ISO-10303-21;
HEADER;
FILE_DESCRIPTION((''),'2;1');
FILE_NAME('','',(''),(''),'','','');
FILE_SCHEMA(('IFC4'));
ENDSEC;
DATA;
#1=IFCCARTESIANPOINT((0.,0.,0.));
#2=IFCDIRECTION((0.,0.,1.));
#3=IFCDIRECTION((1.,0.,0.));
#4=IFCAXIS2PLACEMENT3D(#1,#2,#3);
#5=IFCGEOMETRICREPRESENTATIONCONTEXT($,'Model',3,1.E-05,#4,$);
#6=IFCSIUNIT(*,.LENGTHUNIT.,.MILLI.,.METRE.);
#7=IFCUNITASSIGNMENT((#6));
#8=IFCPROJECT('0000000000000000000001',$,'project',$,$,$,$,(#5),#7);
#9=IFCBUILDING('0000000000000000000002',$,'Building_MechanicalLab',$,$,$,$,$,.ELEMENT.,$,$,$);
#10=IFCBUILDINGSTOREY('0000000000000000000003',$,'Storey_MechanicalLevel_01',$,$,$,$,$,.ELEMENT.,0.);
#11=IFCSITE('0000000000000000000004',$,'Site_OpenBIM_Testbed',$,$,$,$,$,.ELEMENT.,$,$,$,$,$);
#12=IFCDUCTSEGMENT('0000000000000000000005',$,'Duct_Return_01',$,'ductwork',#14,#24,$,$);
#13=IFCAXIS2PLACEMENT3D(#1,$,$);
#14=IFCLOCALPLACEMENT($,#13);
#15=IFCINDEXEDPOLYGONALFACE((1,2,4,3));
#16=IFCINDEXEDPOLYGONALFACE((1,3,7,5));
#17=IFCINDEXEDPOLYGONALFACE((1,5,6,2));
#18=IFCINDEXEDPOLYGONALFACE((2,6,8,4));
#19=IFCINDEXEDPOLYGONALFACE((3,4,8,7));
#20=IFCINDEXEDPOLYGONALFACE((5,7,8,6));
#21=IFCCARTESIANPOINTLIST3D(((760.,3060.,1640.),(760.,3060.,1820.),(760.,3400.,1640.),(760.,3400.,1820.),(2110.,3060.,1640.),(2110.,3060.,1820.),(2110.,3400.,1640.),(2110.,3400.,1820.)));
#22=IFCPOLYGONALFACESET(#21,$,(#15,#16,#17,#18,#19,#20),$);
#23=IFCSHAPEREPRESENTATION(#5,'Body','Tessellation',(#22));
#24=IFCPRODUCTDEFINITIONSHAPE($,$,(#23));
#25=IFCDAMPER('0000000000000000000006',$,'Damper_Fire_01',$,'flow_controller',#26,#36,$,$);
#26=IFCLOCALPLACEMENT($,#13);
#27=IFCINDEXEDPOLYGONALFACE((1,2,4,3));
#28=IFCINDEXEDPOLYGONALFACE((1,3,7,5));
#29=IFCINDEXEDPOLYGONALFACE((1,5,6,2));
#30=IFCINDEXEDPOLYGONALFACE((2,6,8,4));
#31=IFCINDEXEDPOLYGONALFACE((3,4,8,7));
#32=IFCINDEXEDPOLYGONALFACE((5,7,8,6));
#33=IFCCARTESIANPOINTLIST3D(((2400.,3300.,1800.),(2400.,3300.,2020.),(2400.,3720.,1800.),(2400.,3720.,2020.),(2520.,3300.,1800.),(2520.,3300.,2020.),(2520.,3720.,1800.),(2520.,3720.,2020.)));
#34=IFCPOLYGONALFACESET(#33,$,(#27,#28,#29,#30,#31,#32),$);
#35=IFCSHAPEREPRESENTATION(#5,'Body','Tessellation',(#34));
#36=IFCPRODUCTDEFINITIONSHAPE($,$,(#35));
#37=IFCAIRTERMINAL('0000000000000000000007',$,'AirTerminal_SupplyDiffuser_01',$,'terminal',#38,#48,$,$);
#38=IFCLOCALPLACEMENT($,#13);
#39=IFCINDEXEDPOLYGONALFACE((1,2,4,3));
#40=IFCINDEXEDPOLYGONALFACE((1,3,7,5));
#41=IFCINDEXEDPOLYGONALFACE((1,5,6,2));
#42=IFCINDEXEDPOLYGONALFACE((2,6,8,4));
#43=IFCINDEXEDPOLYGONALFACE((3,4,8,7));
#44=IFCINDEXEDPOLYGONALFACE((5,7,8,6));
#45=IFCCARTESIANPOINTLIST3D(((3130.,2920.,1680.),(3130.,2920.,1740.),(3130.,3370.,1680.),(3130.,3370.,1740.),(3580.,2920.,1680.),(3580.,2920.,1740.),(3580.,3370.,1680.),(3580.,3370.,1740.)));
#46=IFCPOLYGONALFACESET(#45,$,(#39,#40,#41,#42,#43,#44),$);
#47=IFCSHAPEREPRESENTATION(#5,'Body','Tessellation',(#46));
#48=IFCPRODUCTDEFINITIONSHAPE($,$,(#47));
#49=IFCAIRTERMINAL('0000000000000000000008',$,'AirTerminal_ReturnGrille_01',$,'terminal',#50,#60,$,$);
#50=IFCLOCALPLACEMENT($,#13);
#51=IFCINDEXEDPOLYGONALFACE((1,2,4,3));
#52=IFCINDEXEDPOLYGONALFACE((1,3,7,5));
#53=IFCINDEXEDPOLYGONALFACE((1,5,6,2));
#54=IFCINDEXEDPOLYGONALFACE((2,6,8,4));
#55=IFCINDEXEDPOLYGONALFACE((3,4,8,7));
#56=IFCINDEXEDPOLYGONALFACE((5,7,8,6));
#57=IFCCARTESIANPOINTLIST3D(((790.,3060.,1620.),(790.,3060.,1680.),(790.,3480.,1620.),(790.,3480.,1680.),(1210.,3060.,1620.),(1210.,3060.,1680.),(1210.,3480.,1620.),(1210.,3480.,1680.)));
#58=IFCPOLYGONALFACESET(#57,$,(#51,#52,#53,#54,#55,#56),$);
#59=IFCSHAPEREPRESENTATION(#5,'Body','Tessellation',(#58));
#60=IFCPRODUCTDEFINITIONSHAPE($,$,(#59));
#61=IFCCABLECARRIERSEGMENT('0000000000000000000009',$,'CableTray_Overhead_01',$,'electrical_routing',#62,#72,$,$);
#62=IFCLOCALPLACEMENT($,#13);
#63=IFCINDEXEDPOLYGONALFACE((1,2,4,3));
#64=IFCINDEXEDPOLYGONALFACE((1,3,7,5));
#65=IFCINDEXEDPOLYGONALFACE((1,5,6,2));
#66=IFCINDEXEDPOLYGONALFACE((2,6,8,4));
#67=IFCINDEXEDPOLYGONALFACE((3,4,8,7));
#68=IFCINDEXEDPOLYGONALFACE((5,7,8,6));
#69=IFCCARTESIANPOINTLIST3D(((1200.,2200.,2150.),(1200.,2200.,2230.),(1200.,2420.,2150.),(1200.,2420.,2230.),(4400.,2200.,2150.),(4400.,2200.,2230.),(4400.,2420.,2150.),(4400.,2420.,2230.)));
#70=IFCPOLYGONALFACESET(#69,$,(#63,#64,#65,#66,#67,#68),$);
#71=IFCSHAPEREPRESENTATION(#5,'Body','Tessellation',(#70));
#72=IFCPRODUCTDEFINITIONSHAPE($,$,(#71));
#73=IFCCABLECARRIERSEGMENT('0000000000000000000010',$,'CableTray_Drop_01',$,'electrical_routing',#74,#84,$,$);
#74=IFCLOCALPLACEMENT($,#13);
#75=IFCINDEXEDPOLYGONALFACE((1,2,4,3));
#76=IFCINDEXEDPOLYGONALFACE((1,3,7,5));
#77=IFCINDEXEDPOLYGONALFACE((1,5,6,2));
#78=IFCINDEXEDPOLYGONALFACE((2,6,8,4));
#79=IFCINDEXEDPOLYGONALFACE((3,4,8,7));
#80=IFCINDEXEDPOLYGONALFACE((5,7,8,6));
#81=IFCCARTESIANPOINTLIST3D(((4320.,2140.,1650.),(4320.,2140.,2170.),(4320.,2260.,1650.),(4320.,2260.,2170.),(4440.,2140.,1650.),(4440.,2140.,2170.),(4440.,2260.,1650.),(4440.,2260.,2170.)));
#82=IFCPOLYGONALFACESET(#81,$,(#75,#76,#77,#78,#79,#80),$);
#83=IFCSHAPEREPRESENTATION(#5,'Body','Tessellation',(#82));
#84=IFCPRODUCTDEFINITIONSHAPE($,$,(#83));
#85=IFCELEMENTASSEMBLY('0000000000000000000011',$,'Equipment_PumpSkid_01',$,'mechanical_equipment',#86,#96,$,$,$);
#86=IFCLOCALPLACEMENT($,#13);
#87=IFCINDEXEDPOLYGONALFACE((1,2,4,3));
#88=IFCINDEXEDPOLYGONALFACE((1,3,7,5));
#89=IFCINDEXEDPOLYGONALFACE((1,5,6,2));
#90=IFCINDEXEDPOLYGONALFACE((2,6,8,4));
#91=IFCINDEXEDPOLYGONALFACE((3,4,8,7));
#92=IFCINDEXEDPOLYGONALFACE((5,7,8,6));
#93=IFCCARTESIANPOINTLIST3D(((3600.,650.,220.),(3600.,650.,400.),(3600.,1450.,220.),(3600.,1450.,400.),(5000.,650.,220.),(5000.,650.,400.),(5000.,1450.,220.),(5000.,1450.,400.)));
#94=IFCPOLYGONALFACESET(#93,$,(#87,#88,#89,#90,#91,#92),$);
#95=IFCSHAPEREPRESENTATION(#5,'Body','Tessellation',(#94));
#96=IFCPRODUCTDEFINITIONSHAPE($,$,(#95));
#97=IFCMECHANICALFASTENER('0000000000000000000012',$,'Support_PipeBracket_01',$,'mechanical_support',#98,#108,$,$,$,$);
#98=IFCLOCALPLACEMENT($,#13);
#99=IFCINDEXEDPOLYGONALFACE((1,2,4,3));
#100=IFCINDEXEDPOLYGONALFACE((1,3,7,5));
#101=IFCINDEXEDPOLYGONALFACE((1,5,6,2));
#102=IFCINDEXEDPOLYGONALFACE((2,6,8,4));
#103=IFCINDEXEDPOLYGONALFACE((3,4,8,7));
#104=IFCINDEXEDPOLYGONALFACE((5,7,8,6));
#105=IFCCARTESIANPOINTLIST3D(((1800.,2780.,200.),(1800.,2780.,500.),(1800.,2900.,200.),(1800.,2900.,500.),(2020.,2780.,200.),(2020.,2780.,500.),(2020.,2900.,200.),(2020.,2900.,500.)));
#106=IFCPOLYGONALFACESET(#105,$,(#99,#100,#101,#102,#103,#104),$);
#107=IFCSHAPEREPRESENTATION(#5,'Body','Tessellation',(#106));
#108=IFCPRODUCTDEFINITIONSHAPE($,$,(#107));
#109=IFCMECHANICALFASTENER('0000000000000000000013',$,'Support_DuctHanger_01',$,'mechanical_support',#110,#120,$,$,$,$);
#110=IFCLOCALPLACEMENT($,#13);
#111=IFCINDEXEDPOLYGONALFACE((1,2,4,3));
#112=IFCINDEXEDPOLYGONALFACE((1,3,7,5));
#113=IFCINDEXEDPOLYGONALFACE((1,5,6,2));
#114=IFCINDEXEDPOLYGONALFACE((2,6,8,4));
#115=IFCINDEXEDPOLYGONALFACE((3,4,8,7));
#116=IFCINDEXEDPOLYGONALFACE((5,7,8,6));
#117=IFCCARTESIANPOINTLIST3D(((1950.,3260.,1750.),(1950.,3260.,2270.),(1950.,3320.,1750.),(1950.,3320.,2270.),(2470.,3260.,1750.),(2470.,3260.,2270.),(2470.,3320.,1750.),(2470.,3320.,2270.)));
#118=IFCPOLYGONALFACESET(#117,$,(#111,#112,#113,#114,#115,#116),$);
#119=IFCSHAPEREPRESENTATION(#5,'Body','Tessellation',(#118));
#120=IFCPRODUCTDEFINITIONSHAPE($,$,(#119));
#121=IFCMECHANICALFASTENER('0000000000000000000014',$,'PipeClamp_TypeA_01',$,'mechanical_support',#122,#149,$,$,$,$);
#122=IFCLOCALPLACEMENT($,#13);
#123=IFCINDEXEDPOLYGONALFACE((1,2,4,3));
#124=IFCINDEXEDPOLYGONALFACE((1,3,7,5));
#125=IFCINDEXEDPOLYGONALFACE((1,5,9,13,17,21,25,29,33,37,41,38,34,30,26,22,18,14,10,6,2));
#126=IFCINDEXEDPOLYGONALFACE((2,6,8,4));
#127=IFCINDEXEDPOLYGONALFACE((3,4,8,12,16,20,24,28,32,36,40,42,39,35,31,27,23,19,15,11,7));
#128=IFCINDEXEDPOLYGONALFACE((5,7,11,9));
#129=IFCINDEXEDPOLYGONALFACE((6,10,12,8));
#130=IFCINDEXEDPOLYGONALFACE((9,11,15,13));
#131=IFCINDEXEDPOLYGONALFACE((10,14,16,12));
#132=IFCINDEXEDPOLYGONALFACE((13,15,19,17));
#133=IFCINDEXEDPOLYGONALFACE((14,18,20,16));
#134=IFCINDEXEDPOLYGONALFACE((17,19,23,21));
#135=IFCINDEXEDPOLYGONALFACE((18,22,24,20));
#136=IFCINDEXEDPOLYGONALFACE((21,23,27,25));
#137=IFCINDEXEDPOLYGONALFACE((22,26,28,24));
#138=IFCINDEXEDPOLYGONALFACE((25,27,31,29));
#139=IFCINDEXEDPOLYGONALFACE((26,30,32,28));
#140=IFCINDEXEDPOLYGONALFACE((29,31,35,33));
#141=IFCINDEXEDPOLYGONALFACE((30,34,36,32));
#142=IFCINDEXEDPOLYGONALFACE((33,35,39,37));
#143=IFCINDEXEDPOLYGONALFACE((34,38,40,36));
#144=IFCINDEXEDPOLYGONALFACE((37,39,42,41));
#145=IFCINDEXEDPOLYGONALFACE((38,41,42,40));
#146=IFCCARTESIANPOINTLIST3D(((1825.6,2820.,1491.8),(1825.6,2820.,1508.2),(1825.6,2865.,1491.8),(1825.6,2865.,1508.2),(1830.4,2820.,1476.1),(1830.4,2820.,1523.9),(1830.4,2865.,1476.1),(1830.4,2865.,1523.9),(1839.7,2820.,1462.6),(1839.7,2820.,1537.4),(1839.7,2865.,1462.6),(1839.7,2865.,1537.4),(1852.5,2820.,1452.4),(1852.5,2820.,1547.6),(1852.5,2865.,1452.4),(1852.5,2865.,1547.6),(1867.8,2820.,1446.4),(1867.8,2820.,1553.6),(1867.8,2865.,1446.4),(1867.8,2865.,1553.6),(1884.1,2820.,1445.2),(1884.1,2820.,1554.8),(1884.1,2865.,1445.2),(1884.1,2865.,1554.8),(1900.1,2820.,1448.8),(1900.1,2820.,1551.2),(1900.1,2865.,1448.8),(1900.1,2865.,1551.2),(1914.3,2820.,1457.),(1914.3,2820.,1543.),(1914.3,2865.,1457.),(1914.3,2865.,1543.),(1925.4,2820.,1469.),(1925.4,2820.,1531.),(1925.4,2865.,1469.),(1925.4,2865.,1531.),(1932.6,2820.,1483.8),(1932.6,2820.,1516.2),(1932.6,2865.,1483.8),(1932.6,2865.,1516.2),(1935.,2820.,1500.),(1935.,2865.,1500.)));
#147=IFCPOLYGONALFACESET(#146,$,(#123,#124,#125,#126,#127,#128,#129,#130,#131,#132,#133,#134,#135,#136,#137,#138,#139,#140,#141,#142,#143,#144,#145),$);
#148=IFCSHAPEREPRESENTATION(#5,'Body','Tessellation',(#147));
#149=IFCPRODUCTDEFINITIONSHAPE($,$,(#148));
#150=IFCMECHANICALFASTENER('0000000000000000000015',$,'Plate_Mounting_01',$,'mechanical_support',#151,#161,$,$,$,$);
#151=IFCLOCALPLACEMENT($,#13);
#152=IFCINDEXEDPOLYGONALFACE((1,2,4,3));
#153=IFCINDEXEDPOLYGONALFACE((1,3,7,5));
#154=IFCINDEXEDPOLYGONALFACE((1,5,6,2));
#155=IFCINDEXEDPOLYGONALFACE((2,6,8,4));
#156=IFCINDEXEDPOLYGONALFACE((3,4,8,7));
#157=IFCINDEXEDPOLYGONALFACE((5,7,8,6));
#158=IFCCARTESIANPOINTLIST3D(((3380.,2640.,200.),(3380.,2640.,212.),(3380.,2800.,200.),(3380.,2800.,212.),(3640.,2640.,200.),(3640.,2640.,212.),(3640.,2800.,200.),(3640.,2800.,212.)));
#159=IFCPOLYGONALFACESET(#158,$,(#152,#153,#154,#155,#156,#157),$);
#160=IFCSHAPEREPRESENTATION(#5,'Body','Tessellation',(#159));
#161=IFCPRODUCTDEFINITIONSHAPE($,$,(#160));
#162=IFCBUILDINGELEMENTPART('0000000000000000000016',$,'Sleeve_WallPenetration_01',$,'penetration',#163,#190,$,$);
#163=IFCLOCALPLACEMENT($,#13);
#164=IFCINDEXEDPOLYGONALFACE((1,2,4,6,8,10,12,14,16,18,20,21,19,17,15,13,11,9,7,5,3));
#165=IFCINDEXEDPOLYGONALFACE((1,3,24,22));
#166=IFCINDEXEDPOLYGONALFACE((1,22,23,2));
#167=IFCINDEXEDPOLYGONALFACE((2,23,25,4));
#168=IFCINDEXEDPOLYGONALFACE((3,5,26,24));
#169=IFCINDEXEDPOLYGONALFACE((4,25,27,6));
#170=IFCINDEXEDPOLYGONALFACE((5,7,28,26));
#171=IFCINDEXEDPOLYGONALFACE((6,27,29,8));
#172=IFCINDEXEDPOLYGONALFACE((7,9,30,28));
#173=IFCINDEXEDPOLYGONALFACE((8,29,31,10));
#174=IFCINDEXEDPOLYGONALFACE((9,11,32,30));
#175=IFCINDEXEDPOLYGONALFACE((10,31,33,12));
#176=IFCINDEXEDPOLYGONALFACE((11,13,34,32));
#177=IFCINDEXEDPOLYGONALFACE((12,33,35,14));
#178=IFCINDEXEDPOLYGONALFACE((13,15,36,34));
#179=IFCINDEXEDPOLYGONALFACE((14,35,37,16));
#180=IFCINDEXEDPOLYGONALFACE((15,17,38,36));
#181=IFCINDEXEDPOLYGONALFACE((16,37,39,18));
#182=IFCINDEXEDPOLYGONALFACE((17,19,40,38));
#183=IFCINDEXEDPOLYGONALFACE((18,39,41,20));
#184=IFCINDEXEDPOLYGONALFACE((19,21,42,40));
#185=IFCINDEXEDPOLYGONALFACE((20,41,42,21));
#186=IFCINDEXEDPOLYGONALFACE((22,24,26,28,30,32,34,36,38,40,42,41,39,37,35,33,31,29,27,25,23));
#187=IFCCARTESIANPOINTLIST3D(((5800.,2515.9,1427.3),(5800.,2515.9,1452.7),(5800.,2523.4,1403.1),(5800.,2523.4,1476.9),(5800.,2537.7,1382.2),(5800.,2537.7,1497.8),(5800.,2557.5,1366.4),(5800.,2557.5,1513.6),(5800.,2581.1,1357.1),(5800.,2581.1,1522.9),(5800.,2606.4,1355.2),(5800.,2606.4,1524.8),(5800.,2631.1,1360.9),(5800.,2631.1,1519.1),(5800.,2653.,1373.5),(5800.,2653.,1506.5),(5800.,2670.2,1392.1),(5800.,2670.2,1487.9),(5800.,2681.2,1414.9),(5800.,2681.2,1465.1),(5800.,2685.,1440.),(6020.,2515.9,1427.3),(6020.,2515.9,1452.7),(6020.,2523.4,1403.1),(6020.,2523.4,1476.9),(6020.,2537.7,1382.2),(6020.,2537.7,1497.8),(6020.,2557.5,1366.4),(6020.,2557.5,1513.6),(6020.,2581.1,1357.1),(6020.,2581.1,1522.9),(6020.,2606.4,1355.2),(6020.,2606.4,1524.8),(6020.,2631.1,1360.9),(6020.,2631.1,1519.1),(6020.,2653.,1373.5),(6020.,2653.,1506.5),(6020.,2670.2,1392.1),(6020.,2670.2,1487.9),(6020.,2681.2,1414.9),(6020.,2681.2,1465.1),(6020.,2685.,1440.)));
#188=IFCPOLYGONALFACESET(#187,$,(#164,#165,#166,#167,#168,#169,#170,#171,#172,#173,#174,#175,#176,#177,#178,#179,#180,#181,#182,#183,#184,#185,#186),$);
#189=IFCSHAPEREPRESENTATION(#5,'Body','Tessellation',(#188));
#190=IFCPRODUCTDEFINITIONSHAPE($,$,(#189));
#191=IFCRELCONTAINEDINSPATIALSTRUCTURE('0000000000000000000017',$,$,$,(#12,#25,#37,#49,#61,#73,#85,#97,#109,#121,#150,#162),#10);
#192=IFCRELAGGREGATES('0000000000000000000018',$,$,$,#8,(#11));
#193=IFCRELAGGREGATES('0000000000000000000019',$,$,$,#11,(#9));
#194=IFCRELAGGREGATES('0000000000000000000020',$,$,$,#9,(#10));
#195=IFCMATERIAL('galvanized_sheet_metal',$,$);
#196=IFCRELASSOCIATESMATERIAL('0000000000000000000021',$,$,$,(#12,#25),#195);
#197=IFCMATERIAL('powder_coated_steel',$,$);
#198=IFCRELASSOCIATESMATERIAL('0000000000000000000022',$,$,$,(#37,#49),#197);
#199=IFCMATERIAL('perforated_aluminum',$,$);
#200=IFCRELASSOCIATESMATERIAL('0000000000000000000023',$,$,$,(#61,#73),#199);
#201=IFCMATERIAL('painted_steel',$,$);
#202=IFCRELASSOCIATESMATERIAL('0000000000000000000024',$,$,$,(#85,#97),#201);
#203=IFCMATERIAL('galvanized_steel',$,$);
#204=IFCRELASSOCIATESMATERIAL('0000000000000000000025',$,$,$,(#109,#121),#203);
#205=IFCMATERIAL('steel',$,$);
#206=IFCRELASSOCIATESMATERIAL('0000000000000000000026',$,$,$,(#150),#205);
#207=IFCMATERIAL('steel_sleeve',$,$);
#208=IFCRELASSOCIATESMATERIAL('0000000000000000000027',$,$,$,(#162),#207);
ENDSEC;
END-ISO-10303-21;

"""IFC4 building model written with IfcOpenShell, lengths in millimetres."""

from ifc_helpers import new_model, si_unit, frame, origin_with_axes, place, context, project, spatial, rectangle, circle, extrude, material, element, save


model = new_model("IFC4")

# Units and contexts
model_context = context("Model", 3, precision=1e-05, world=origin_with_axes())
ifc_project = project(units=[si_unit("LENGTHUNIT", "METRE", prefix="MILLI")], contexts=[model_context])

# Site, building, storey
site = spatial("IfcSite", under=ifc_project, Name="Site_OpenBIM_Testbed", CompositionType="ELEMENT")
building = spatial("IfcBuilding", under=site, Name="Building_MechanicalLab", CompositionType="ELEMENT")
storey = spatial("IfcBuildingStorey", under=building, Name="Storey_MechanicalLevel_01", CompositionType="ELEMENT", Elevation=0.0)

# Shared definitions
ifc_material_1 = material(Name="painted_steel")

# Duct segment
ifc_material_2 = material(Name="galvanized_sheet_metal")
duct_segment_1_placement = place(None, frame((760.0, 3060.0, 1640.0), z_axis=(0.0, 0.0, 1.0), x_axis=(1.0, 0.0, 0.0)))
element("IfcDuctSegment", 1, at=duct_segment_1_placement, inside=storey, material=ifc_material_2, Name="Duct_Return_01", ObjectType="ductwork", context=model_context, shape_type="SweptSolid", body=[
    extrude(rectangle(XDim=1350.0, YDim=340.0), frame((675.0, 170.0, 0.0), z_axis=(0.0, 0.0, 1.0), x_axis=(1.0, 0.0, 0.0)), (0.0, 0.0, 1.0), 180.0),
])

# Damper
damper_placement = place(None, frame((2400.0, 3300.0, 1800.0), z_axis=(0.0, 0.0, 1.0), x_axis=(1.0, 0.0, 0.0)))
element("IfcDamper", 2, at=damper_placement, inside=storey, material=ifc_material_2, Name="Damper_Fire_01", ObjectType="flow_controller", context=model_context, shape_type="SweptSolid", body=[
    extrude(rectangle(XDim=120.0, YDim=420.0), frame((60.0, 210.0, 0.0), z_axis=(0.0, 0.0, 1.0), x_axis=(1.0, 0.0, 0.0)), (0.0, 0.0, 1.0), 220.0),
])

# Air terminals
ifc_material_3 = material(Name="powder_coated_steel")
air_terminal_1_placement = place(None, frame((3130.0, 2920.0, 1680.0), z_axis=(0.0, 0.0, 1.0), x_axis=(1.0, 0.0, 0.0)))
element("IfcAirTerminal", 3, at=air_terminal_1_placement, inside=storey, material=ifc_material_3, Name="AirTerminal_SupplyDiffuser_01", ObjectType="terminal", context=model_context, shape_type="SweptSolid", body=[
    extrude(rectangle(XDim=450.0, YDim=450.0), frame((225.0, 225.0, 0.0), z_axis=(0.0, 0.0, 1.0), x_axis=(1.0, 0.0, 0.0)), (0.0, 0.0, 1.0), 60.0),
])
air_terminal_2_placement = place(None, frame((790.0, 3060.0, 1620.0), z_axis=(0.0, 0.0, 1.0), x_axis=(1.0, 0.0, 0.0)))
element("IfcAirTerminal", 4, at=air_terminal_2_placement, inside=storey, material=ifc_material_3, Name="AirTerminal_ReturnGrille_01", ObjectType="terminal", context=model_context, shape_type="SweptSolid", body=[
    extrude(rectangle(XDim=420.0, YDim=420.0), frame((210.0, 210.0, 0.0), z_axis=(0.0, 0.0, 1.0), x_axis=(1.0, 0.0, 0.0)), (0.0, 0.0, 1.0), 60.0),
])

# Cable carrier segments
ifc_material_4 = material(Name="perforated_aluminum")
cable_carrier_segment_1_placement = place(None, frame((1200.0, 2200.0, 2150.0), z_axis=(0.0, 0.0, 1.0), x_axis=(1.0, 0.0, 0.0)))
element("IfcCableCarrierSegment", 5, at=cable_carrier_segment_1_placement, inside=storey, material=ifc_material_4, Name="CableTray_Overhead_01", ObjectType="electrical_routing", context=model_context, shape_type="SweptSolid", body=[
    extrude(rectangle(XDim=3200.0, YDim=220.0), frame((1600.0, 110.0, 0.0), z_axis=(0.0, 0.0, 1.0), x_axis=(1.0, 0.0, 0.0)), (0.0, 0.0, 1.0), 80.0),
])
cable_carrier_segment_2_placement = place(None, frame((4320.0, 2140.0, 1650.0), z_axis=(0.0, 0.0, 1.0), x_axis=(1.0, 0.0, 0.0)))
element("IfcCableCarrierSegment", 6, at=cable_carrier_segment_2_placement, inside=storey, material=ifc_material_4, Name="CableTray_Drop_01", ObjectType="electrical_routing", context=model_context, shape_type="SweptSolid", body=[
    extrude(rectangle(XDim=120.0, YDim=120.0), frame((60.0, 60.0, 0.0), z_axis=(0.0, 0.0, 1.0), x_axis=(1.0, 0.0, 0.0)), (0.0, 0.0, 1.0), 520.0),
])

# Element assembly
assembly_placement = place(None, frame((3600.0, 650.0, 220.0), z_axis=(0.0, 0.0, 1.0), x_axis=(1.0, 0.0, 0.0)))
element("IfcElementAssembly", 7, at=assembly_placement, inside=storey, material=ifc_material_1, Name="Equipment_PumpSkid_01", ObjectType="mechanical_equipment", context=model_context, shape_type="SweptSolid", body=[
    extrude(rectangle(XDim=1400.0, YDim=800.0), frame((700.0, 400.0, 0.0), z_axis=(0.0, 0.0, 1.0), x_axis=(1.0, 0.0, 0.0)), (0.0, 0.0, 1.0), 180.0),
])

# Mechanical fasteners
mechanical_fastener_1_placement = place(None, frame((1800.0, 2780.0, 200.0), z_axis=(0.0, 0.0, 1.0), x_axis=(1.0, 0.0, 0.0)))
element("IfcMechanicalFastener", 8, at=mechanical_fastener_1_placement, inside=storey, material=ifc_material_1, Name="Support_PipeBracket_01", ObjectType="mechanical_support", context=model_context, shape_type="SweptSolid", body=[
    extrude(rectangle(XDim=220.0, YDim=120.0), frame((110.0, 60.0, 0.0), z_axis=(0.0, 0.0, 1.0), x_axis=(1.0, 0.0, 0.0)), (0.0, 0.0, 1.0), 300.0),
])
ifc_material_5 = material(Name="galvanized_steel")
mechanical_fastener_2_placement = place(None, frame((1950.0, 3260.0, 1750.0), z_axis=(0.0, 0.0, 1.0), x_axis=(1.0, 0.0, 0.0)))
element("IfcMechanicalFastener", 9, at=mechanical_fastener_2_placement, inside=storey, material=ifc_material_5, Name="Support_DuctHanger_01", ObjectType="mechanical_support", context=model_context, shape_type="SweptSolid", body=[
    extrude(rectangle(XDim=520.0, YDim=60.0), frame((260.0, 30.0, 0.0), z_axis=(0.0, 0.0, 1.0), x_axis=(1.0, 0.0, 0.0)), (0.0, 0.0, 1.0), 520.0),
])
mechanical_fastener_3_placement = place(None, frame((1880.0, 2820.0, 1500.0), z_axis=(0.0, 0.0, 1.0), x_axis=(1.0, 0.0, 0.0)))
element("IfcMechanicalFastener", 10, at=mechanical_fastener_3_placement, inside=storey, material=ifc_material_5, Name="PipeClamp_TypeA_01", ObjectType="mechanical_support", context=model_context, shape_type="SweptSolid", body=[
    extrude(circle(Radius=55.0), frame((0.0, 0.0, 0.0), z_axis=(0.0, 1.0, 0.0), x_axis=(1.0, 0.0, 0.0)), (0.0, 0.0, 1.0), 45.0),
])
ifc_material_6 = material(Name="steel")
mechanical_fastener_4_placement = place(None, frame((3380.0, 2640.0, 200.0), z_axis=(0.0, 0.0, 1.0), x_axis=(1.0, 0.0, 0.0)))
element("IfcMechanicalFastener", 11, at=mechanical_fastener_4_placement, inside=storey, material=ifc_material_6, Name="Plate_Mounting_01", ObjectType="mechanical_support", context=model_context, shape_type="SweptSolid", body=[
    extrude(rectangle(XDim=260.0, YDim=160.0), frame((130.0, 80.0, 0.0), z_axis=(0.0, 0.0, 1.0), x_axis=(1.0, 0.0, 0.0)), (0.0, 0.0, 1.0), 12.0),
])

# Building element part
ifc_material_7 = material(Name="steel_sleeve")
building_element_part_placement = place(None, frame((5800.0, 2600.0, 1440.0), z_axis=(0.0, 0.0, 1.0), x_axis=(1.0, 0.0, 0.0)))
element("IfcBuildingElementPart", 12, at=building_element_part_placement, inside=storey, material=ifc_material_7, Name="Sleeve_WallPenetration_01", ObjectType="penetration", context=model_context, shape_type="SweptSolid", body=[
    extrude(circle(Radius=85.0), frame((0.0, 0.0, 0.0), z_axis=(1.0, 0.0, 0.0), x_axis=(0.0, 1.0, 0.0)), (0.0, 0.0, 1.0), 220.0),
])

save(model, "model.ifc")
